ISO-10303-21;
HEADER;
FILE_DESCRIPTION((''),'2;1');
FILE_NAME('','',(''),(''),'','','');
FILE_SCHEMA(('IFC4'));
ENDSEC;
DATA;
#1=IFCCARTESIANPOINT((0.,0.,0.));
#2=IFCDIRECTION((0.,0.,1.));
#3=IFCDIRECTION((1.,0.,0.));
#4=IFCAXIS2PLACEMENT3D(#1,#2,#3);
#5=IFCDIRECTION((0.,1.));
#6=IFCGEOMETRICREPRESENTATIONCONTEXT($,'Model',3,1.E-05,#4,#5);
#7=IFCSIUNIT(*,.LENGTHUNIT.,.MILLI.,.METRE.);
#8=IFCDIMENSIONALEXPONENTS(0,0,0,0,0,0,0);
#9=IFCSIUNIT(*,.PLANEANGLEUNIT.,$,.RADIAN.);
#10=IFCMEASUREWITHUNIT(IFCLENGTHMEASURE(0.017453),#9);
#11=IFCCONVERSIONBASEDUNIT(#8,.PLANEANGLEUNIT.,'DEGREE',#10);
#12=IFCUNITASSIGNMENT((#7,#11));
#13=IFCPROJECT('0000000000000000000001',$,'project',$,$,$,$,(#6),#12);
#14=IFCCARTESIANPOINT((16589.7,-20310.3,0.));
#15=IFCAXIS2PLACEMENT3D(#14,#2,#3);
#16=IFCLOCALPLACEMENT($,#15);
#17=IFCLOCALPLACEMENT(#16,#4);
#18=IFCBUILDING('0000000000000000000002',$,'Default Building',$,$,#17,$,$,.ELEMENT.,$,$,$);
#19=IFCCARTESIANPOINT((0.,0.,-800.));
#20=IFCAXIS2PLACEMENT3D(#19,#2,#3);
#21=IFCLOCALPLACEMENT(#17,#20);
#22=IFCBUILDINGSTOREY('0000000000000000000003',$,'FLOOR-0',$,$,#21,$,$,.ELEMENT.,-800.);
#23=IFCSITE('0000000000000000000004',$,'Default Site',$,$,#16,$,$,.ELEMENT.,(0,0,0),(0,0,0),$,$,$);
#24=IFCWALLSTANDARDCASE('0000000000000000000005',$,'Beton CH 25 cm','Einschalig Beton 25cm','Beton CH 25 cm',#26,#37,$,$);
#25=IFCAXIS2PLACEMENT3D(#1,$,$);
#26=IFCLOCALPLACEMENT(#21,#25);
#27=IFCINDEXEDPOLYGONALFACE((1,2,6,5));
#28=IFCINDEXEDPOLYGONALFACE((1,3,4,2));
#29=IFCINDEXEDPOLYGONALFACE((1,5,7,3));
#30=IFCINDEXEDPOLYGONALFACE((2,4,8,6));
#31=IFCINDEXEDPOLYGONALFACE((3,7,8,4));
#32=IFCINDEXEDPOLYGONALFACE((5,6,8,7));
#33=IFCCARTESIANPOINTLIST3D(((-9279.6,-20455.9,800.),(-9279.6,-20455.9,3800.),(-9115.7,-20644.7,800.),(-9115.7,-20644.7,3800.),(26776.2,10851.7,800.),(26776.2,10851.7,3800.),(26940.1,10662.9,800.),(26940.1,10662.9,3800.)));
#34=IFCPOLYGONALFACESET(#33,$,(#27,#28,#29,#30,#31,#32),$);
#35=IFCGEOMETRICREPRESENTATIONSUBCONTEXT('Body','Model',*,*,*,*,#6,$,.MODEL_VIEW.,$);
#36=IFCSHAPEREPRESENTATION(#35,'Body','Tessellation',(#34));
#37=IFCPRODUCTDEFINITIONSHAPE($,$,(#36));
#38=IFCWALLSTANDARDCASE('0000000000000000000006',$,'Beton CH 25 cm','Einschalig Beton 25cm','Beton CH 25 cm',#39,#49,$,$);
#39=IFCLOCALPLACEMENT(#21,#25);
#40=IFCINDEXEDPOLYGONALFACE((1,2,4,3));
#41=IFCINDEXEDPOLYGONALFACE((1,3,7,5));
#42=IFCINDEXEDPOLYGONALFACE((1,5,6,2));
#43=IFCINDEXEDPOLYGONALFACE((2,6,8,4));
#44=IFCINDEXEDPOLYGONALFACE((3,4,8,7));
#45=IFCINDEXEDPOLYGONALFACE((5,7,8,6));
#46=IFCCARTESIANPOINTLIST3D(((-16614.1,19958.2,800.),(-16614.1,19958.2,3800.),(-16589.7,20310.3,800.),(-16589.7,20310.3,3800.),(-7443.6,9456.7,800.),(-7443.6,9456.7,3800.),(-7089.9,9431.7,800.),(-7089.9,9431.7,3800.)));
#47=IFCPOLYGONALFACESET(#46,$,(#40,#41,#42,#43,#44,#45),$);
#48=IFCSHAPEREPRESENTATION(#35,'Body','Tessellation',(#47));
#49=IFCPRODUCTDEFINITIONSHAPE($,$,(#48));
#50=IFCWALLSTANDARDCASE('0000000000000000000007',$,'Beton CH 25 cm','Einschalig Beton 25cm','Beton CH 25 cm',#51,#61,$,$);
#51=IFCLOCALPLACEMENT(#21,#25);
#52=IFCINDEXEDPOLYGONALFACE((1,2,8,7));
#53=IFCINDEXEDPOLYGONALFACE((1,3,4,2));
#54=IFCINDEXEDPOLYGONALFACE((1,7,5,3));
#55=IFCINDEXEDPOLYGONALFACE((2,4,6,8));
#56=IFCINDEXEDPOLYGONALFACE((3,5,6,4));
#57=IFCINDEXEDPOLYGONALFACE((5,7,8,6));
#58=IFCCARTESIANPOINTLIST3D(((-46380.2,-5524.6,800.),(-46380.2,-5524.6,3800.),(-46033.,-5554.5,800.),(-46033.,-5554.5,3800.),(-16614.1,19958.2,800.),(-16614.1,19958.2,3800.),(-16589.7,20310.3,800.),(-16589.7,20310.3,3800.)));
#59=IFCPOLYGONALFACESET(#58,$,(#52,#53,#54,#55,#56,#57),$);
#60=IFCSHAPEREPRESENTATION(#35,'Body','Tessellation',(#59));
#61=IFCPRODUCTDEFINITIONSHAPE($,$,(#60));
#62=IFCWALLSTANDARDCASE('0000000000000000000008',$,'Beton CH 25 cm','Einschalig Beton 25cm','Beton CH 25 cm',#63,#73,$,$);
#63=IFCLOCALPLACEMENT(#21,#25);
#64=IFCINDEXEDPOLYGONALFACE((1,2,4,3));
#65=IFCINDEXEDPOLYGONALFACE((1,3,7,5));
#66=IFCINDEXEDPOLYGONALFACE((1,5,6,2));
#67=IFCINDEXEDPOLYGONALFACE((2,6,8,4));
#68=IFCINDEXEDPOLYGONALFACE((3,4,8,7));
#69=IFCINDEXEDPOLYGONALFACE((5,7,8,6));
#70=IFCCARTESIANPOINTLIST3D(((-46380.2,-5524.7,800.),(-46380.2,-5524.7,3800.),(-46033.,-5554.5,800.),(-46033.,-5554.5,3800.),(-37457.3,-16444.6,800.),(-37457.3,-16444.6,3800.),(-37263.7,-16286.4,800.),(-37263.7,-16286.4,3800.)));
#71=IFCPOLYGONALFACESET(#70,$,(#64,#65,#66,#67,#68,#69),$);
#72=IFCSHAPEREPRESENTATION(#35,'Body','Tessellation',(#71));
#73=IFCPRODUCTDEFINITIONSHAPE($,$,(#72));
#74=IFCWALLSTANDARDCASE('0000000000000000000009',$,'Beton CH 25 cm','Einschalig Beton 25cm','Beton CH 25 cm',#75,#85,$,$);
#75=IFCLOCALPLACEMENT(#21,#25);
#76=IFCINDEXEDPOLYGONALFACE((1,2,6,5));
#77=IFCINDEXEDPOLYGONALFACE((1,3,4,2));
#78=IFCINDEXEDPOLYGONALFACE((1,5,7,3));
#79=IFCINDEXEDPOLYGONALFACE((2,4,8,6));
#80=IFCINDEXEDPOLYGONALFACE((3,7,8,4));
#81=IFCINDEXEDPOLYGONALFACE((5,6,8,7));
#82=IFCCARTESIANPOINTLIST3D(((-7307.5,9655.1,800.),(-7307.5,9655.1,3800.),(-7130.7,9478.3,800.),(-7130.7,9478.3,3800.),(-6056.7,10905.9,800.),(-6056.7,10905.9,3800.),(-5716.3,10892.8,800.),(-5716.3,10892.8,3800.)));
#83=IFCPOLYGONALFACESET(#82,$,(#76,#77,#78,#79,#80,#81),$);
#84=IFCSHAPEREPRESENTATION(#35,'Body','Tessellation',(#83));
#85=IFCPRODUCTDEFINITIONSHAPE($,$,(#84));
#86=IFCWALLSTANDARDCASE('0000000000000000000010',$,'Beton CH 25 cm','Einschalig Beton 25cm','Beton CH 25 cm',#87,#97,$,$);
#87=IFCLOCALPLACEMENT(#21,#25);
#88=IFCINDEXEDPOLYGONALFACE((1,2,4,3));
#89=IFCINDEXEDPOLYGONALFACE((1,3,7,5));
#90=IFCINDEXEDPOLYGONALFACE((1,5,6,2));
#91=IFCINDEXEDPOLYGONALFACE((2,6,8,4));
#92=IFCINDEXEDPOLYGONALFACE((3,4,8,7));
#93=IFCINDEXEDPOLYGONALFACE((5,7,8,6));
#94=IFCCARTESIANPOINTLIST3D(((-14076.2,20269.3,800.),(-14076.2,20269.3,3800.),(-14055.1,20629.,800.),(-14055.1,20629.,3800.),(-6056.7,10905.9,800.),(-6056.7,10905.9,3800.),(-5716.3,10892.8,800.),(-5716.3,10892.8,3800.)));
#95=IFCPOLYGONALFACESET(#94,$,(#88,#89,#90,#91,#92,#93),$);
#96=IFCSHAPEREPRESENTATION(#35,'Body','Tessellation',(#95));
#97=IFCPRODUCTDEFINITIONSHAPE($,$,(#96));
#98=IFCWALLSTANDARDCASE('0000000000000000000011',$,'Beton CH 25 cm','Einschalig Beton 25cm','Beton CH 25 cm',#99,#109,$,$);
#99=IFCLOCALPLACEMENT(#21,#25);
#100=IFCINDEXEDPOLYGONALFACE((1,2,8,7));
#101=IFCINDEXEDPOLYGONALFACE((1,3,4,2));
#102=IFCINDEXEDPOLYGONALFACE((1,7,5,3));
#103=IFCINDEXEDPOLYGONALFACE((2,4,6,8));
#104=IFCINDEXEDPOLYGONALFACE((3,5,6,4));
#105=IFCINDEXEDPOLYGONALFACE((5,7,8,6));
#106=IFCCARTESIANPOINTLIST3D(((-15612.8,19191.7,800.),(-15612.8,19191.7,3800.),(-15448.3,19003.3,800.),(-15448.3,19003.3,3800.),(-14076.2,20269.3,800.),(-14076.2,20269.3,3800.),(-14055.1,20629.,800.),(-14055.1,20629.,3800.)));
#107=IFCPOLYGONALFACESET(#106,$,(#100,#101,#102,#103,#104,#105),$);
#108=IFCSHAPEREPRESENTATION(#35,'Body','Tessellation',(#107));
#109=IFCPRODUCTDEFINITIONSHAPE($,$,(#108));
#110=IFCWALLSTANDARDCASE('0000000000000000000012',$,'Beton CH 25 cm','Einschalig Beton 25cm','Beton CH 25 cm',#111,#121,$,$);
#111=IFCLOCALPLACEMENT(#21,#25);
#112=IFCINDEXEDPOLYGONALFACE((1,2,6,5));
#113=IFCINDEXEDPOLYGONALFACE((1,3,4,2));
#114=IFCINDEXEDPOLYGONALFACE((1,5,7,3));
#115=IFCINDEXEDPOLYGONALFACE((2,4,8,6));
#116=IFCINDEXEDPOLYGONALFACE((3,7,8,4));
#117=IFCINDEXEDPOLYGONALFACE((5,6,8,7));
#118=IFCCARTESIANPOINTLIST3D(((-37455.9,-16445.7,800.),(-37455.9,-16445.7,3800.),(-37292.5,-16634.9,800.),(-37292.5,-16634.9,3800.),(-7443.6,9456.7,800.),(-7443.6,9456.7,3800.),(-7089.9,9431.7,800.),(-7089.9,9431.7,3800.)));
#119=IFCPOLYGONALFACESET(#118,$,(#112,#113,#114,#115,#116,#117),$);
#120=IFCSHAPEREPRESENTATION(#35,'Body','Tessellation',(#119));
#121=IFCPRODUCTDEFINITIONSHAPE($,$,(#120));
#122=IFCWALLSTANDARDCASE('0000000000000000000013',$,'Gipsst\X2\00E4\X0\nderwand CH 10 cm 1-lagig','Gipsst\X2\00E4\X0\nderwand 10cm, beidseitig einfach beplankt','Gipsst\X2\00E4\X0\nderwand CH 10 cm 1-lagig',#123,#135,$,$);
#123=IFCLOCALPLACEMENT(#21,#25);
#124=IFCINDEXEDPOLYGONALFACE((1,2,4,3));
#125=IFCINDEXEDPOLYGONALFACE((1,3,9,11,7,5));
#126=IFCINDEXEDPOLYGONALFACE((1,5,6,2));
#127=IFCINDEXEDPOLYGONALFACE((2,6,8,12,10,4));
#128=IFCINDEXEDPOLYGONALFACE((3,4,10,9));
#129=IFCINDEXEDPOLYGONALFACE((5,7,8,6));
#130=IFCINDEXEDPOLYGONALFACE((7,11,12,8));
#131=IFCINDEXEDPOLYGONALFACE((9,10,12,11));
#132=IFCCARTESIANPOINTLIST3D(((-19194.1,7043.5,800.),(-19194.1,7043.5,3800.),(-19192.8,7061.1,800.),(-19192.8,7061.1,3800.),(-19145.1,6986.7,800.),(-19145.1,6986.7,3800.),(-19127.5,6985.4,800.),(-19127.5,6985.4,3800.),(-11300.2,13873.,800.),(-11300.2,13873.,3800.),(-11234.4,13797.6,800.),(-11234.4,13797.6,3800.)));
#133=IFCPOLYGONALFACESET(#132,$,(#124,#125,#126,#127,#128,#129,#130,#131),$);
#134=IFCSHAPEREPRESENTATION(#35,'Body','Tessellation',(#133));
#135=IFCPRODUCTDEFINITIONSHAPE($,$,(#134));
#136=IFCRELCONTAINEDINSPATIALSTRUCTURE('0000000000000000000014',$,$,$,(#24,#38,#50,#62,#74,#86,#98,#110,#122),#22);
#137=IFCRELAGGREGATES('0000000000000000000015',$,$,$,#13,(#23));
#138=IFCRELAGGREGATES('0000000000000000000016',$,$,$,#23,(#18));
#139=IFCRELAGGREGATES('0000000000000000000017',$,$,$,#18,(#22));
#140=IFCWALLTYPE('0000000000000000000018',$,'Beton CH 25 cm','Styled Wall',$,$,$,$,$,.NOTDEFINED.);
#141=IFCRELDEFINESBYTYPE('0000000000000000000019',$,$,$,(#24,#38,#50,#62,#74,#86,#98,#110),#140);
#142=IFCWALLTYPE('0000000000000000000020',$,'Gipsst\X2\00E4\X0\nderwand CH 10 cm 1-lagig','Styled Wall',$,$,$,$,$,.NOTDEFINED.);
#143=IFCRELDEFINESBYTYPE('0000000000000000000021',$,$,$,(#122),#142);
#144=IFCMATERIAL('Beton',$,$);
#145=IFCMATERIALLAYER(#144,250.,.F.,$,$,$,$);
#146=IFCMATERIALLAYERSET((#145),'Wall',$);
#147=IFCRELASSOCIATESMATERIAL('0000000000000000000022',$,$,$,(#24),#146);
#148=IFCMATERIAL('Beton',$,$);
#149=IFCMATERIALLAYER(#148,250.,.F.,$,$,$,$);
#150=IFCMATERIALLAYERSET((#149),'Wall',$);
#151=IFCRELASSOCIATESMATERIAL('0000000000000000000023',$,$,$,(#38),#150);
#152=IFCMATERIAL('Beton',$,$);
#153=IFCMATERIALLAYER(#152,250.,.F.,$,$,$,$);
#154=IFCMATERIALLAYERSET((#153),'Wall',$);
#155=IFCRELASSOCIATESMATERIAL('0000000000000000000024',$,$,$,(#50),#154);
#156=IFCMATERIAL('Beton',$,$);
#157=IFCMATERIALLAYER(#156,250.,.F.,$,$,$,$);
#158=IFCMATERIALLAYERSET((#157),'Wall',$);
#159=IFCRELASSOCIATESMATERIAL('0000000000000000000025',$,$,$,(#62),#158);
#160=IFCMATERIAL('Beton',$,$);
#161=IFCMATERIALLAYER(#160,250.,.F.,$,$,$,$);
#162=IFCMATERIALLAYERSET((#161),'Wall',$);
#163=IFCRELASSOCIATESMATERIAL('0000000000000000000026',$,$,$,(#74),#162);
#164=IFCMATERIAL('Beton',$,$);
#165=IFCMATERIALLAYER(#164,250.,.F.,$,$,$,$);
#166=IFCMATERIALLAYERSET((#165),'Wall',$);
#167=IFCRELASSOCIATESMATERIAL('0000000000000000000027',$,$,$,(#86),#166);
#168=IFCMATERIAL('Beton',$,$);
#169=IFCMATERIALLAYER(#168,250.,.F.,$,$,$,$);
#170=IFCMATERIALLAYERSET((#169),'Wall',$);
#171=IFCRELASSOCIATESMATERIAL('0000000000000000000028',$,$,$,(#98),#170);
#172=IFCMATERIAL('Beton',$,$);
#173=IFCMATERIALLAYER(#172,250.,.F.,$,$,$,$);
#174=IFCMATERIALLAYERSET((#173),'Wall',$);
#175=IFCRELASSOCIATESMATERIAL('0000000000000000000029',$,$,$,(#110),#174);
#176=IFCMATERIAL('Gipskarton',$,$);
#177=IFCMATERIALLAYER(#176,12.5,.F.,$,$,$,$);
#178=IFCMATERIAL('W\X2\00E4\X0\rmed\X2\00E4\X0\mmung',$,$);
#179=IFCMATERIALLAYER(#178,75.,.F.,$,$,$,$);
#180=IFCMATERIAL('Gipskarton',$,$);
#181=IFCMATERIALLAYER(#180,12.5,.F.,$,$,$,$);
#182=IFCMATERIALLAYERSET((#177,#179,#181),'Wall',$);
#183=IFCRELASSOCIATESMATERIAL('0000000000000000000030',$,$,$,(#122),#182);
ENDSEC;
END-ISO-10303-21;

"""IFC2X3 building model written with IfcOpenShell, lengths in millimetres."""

from ifc_helpers import new_model, entity, si_unit, converted_unit, direction, frame, origin_with_axes, place, context, subcontext, project, spatial, polyline, outline, extrude, material, layer, layer_set, layer_usage, type_object, element, save


model = new_model("IFC2X3")

# Units and contexts
model_context = context("Model", 3, precision=1e-05, world=origin_with_axes(), true_north=direction((0.0, 1.0)))
body_context = subcontext(model_context, "Body", "Model", "MODEL_VIEW")
ifc_project = project(units=[si_unit("LENGTHUNIT", "METRE", prefix="MILLI"), converted_unit("PLANEANGLEUNIT", "DEGREE", entity("IfcLengthMeasure", 0.017453), si_unit("PLANEANGLEUNIT", "RADIAN"), dimensions=[0, 0, 0, 0, 0, 0, 0])], contexts=[model_context])

# Site, building, storey
site_placement = place(None, frame((16589.7, -20310.3, 0.0), z_axis=(0.0, 0.0, 1.0), x_axis=(1.0, 0.0, 0.0)))
site = spatial("IfcSite", under=ifc_project, at=site_placement, Name="Default Site", CompositionType="ELEMENT", RefLatitude=(0, 0, 0), RefLongitude=(0, 0, 0))
building_placement = place(site_placement, origin_with_axes())
building = spatial("IfcBuilding", under=site, at=building_placement, Name="Default Building", CompositionType="ELEMENT")
storey_placement = place(building_placement, frame((0.0, 0.0, -800.0), z_axis=(0.0, 0.0, 1.0), x_axis=(1.0, 0.0, 0.0)))
storey = spatial("IfcBuildingStorey", under=building, at=storey_placement, Name="FLOOR-0", CompositionType="ELEMENT", Elevation=-800.0)

# Walls
ifc_material_1 = material(Name="Beton")
ifc_layer_1 = layer(ifc_material_1, 250.0, ventilated=False)
ifc_layer_set_1 = layer_set([ifc_layer_1], Name="Wall")
ifc_layer_usage_1 = layer_usage(ifc_layer_set_1, "AXIS2", "POSITIVE", -125.0)
wall_type_1 = type_object("IfcWallType", Name="Beton CH 25 cm", Description="Styled Wall", PredefinedType="NOTDEFINED")
wall_1_placement = place(storey_placement, frame((-9197.6, -20550.3, 800.0), z_axis=(0.0, 0.0, 1.0), x_axis=(0.755075, 0.655638, 0.0)))
element("IfcWallStandardCase", 1, at=wall_1_placement, inside=storey, type_object=wall_type_1, material=ifc_layer_usage_1, Name="Beton CH 25 cm", Description="Einschalig Beton 25cm", ObjectType="Beton CH 25 cm", context=body_context, shape_type="SweptSolid", body=[
    extrude(outline(polyline([(0.0, -125.0), (0.0, 125.0), (47751.3, 125.0), (47751.3, -125.0), (0.0, -125.0)])), origin_with_axes(), (0.0, 0.0, 1.0), 3000.0),
])
ifc_material_2 = material(Name="Beton")
ifc_layer_2 = layer(ifc_material_2, 250.0, ventilated=False)
ifc_layer_set_2 = layer_set([ifc_layer_2], Name="Wall")
ifc_layer_usage_2 = layer_usage(ifc_layer_set_2, "AXIS2", "POSITIVE", -125.0)
wall_2_placement = place(storey_placement, frame((-7266.8, 9444.2, 800.0), z_axis=(0.0, 0.0, 1.0), x_axis=(-0.657756, 0.753231, 0.0)))
element("IfcWallStandardCase", 2, at=wall_2_placement, inside=storey, type_object=wall_type_1, material=ifc_layer_usage_2, Name="Beton CH 25 cm", Description="Einschalig Beton 25cm", ObjectType="Beton CH 25 cm", context=body_context, shape_type="SweptSolid", body=[
    extrude(outline(polyline([(14316.9, -125.0), (14067.8, 125.0), (125.7, 125.0), (-125.7, -125.0), (14316.9, -125.0)])), origin_with_axes(), (0.0, 0.0, 1.0), 3000.0),
])
ifc_material_3 = material(Name="Beton")
ifc_layer_3 = layer(ifc_material_3, 250.0, ventilated=False)
ifc_layer_set_3 = layer_set([ifc_layer_3], Name="Wall")
ifc_layer_usage_3 = layer_usage(ifc_layer_set_3, "AXIS2", "POSITIVE", -125.0)
wall_3_placement = place(storey_placement, frame((-16601.9, 20134.3, 800.0), z_axis=(0.0, 0.0, 1.0), x_axis=(-0.755481, -0.65517, 0.0)))
element("IfcWallStandardCase", 3, at=wall_3_placement, inside=storey, type_object=wall_type_1, material=ifc_layer_usage_3, Name="Beton CH 25 cm", Description="Einschalig Beton 25cm", ObjectType="Beton CH 25 cm", context=body_context, shape_type="SweptSolid", body=[
    extrude(outline(polyline([(39307.9, -125.0), (39065.1, 125.0), (124.6, 125.0), (-124.6, -125.0), (39307.9, -125.0)])), origin_with_axes(), (0.0, 0.0, 1.0), 3000.0),
])
ifc_material_4 = material(Name="Beton")
ifc_layer_4 = layer(ifc_material_4, 250.0, ventilated=False)
ifc_layer_set_4 = layer_set([ifc_layer_4], Name="Wall")
ifc_layer_usage_4 = layer_usage(ifc_layer_set_4, "AXIS2", "POSITIVE", -125.0)
wall_4_placement = place(storey_placement, frame((-46206.6, -5539.6, 800.0), z_axis=(0.0, 0.0, 1.0), x_axis=(0.632747, -0.774359, 0.0)))
element("IfcWallStandardCase", 4, at=wall_4_placement, inside=storey, type_object=wall_type_1, material=ifc_layer_usage_4, Name="Beton CH 25 cm", Description="Einschalig Beton 25cm", ObjectType="Beton CH 25 cm", context=body_context, shape_type="SweptSolid", body=[
    extrude(outline(polyline([(13980.5, 125.0), (121.4, 125.0), (-121.4, -125.0), (13980.5, -125.0), (13980.5, 125.0)])), origin_with_axes(), (0.0, 0.0, 1.0), 3000.0),
])
ifc_material_5 = material(Name="Beton")
ifc_layer_5 = layer(ifc_material_5, 250.0, ventilated=False)
ifc_layer_set_5 = layer_set([ifc_layer_5], Name="Wall")
ifc_layer_usage_5 = layer_usage(ifc_layer_set_5, "AXIS2", "POSITIVE", -125.0)
wall_5_placement = place(storey_placement, frame((-7219.1, 9566.7, 800.0), z_axis=(0.0, 0.0, 1.0), x_axis=(0.707107, 0.707107, 0.0)))
element("IfcWallStandardCase", 5, at=wall_5_placement, inside=storey, type_object=wall_type_1, material=ifc_layer_usage_5, Name="Beton CH 25 cm", Description="Einschalig Beton 25cm", ObjectType="Beton CH 25 cm", context=body_context, shape_type="SweptSolid", body=[
    extrude(outline(polyline([(2000.3, -125.0), (1768.9, 125.0), (0.0, 125.0), (0.0, -125.0), (2000.3, -125.0)])), origin_with_axes(), (0.0, 0.0, 1.0), 3000.0),
])
ifc_material_6 = material(Name="Beton")
ifc_layer_6 = layer(ifc_material_6, 250.0, ventilated=False)
ifc_layer_set_6 = layer_set([ifc_layer_6], Name="Wall")
ifc_layer_usage_6 = layer_usage(ifc_layer_set_6, "AXIS2", "POSITIVE", -125.0)
wall_6_placement = place(storey_placement, frame((-5886.5, 10899.3, 800.0), z_axis=(0.0, 0.0, 1.0), x_axis=(-0.650497, 0.759509, 0.0)))
element("IfcWallStandardCase", 6, at=wall_6_placement, inside=storey, type_object=wall_type_1, material=ifc_layer_usage_6, Name="Beton CH 25 cm", Description="Einschalig Beton 25cm", ObjectType="Beton CH 25 cm", context=body_context, shape_type="SweptSolid", body=[
    extrude(outline(polyline([(12703.4, -125.0), (12444.0, 125.0), (115.7, 125.0), (-115.7, -125.0), (12703.4, -125.0)])), origin_with_axes(), (0.0, 0.0, 1.0), 3000.0),
])
ifc_material_7 = material(Name="Beton")
ifc_layer_7 = layer(ifc_material_7, 250.0, ventilated=False)
ifc_layer_set_7 = layer_set([ifc_layer_7], Name="Wall")
ifc_layer_usage_7 = layer_usage(ifc_layer_set_7, "AXIS2", "POSITIVE", -125.0)
wall_7_placement = place(storey_placement, frame((-14065.6, 20449.2, 800.0), z_axis=(0.0, 0.0, 1.0), x_axis=(-0.734932, -0.67814, 0.0)))
element("IfcWallStandardCase", 7, at=wall_7_placement, inside=storey, type_object=wall_type_1, material=ifc_layer_usage_7, Name="Beton CH 25 cm", Description="Einschalig Beton 25cm", ObjectType="Beton CH 25 cm", context=body_context, shape_type="SweptSolid", body=[
    extrude(outline(polyline([(1989.8, -125.0), (1996.7, 125.0), (129.7, 125.0), (-129.7, -125.0), (1989.8, -125.0)])), origin_with_axes(), (0.0, 0.0, 1.0), 3000.0),
])
ifc_material_8 = material(Name="Beton")
ifc_layer_8 = layer(ifc_material_8, 250.0, ventilated=False)
ifc_layer_set_8 = layer_set([ifc_layer_8], Name="Wall")
ifc_layer_usage_8 = layer_usage(ifc_layer_set_8, "AXIS2", "POSITIVE", -125.0)
wall_8_placement = place(storey_placement, frame((-37374.2, -16540.3, 800.0), z_axis=(0.0, 0.0, 1.0), x_axis=(0.757039, 0.65337, 0.0)))
element("IfcWallStandardCase", 8, at=wall_8_placement, inside=storey, type_object=wall_type_1, material=ifc_layer_usage_8, Name="Beton CH 25 cm", Description="Einschalig Beton 25cm", ObjectType="Beton CH 25 cm", context=body_context, shape_type="SweptSolid", body=[
    extrude(outline(polyline([(39895.7, -125.0), (39644.2, 125.0), (0.0, 125.0), (0.0, -125.0), (39895.7, -125.0)])), origin_with_axes(), (0.0, 0.0, 1.0), 3000.0),
])
wall_type_2 = type_object("IfcWallType", Name="Gipsständerwand CH 10 cm 1-lagig", Description="Styled Wall", PredefinedType="NOTDEFINED")
ifc_material_9 = material(Name="Gipskarton")
ifc_layer_9 = layer(ifc_material_9, 12.5, ventilated=False)
ifc_material_10 = material(Name="Wärmedämmung")
ifc_layer_10 = layer(ifc_material_10, 75.0, ventilated=False)
ifc_material_11 = material(Name="Gipskarton")
ifc_layer_11 = layer(ifc_material_11, 12.5, ventilated=False)
ifc_layer_set_9 = layer_set([ifc_layer_9, ifc_layer_10, ifc_layer_11], Name="Wall")
ifc_layer_usage_9 = layer_usage(ifc_layer_set_9, "AXIS2", "NEGATIVE", 50.0)
wall_9_placement = place(storey_placement, frame((-19198.0, 6990.6, 800.0), z_axis=(0.0, 0.0, 1.0), x_axis=(0.757039, 0.65337, 0.0)))
element("IfcWallStandardCase", 9, at=wall_9_placement, inside=storey, type_object=wall_type_2, material=ifc_layer_usage_9, Name="Gipsständerwand CH 10 cm 1-lagig", Description="Gipsständerwand 10cm, beidseitig einfach beplankt", ObjectType="Gipsständerwand CH 10 cm 1-lagig", context=body_context, shape_type="SweptSolid", body=[
    extrude(outline(polyline([(10476.3, -50.0), (10475.7, 50.0), (50.0, 50.0), (37.5, 37.5), (37.5, -37.5), (50.0, -50.0), (10476.3, -50.0)])), origin_with_axes(), (0.0, 0.0, 1.0), 3000.0),
])

save(model, "model.ifc")
